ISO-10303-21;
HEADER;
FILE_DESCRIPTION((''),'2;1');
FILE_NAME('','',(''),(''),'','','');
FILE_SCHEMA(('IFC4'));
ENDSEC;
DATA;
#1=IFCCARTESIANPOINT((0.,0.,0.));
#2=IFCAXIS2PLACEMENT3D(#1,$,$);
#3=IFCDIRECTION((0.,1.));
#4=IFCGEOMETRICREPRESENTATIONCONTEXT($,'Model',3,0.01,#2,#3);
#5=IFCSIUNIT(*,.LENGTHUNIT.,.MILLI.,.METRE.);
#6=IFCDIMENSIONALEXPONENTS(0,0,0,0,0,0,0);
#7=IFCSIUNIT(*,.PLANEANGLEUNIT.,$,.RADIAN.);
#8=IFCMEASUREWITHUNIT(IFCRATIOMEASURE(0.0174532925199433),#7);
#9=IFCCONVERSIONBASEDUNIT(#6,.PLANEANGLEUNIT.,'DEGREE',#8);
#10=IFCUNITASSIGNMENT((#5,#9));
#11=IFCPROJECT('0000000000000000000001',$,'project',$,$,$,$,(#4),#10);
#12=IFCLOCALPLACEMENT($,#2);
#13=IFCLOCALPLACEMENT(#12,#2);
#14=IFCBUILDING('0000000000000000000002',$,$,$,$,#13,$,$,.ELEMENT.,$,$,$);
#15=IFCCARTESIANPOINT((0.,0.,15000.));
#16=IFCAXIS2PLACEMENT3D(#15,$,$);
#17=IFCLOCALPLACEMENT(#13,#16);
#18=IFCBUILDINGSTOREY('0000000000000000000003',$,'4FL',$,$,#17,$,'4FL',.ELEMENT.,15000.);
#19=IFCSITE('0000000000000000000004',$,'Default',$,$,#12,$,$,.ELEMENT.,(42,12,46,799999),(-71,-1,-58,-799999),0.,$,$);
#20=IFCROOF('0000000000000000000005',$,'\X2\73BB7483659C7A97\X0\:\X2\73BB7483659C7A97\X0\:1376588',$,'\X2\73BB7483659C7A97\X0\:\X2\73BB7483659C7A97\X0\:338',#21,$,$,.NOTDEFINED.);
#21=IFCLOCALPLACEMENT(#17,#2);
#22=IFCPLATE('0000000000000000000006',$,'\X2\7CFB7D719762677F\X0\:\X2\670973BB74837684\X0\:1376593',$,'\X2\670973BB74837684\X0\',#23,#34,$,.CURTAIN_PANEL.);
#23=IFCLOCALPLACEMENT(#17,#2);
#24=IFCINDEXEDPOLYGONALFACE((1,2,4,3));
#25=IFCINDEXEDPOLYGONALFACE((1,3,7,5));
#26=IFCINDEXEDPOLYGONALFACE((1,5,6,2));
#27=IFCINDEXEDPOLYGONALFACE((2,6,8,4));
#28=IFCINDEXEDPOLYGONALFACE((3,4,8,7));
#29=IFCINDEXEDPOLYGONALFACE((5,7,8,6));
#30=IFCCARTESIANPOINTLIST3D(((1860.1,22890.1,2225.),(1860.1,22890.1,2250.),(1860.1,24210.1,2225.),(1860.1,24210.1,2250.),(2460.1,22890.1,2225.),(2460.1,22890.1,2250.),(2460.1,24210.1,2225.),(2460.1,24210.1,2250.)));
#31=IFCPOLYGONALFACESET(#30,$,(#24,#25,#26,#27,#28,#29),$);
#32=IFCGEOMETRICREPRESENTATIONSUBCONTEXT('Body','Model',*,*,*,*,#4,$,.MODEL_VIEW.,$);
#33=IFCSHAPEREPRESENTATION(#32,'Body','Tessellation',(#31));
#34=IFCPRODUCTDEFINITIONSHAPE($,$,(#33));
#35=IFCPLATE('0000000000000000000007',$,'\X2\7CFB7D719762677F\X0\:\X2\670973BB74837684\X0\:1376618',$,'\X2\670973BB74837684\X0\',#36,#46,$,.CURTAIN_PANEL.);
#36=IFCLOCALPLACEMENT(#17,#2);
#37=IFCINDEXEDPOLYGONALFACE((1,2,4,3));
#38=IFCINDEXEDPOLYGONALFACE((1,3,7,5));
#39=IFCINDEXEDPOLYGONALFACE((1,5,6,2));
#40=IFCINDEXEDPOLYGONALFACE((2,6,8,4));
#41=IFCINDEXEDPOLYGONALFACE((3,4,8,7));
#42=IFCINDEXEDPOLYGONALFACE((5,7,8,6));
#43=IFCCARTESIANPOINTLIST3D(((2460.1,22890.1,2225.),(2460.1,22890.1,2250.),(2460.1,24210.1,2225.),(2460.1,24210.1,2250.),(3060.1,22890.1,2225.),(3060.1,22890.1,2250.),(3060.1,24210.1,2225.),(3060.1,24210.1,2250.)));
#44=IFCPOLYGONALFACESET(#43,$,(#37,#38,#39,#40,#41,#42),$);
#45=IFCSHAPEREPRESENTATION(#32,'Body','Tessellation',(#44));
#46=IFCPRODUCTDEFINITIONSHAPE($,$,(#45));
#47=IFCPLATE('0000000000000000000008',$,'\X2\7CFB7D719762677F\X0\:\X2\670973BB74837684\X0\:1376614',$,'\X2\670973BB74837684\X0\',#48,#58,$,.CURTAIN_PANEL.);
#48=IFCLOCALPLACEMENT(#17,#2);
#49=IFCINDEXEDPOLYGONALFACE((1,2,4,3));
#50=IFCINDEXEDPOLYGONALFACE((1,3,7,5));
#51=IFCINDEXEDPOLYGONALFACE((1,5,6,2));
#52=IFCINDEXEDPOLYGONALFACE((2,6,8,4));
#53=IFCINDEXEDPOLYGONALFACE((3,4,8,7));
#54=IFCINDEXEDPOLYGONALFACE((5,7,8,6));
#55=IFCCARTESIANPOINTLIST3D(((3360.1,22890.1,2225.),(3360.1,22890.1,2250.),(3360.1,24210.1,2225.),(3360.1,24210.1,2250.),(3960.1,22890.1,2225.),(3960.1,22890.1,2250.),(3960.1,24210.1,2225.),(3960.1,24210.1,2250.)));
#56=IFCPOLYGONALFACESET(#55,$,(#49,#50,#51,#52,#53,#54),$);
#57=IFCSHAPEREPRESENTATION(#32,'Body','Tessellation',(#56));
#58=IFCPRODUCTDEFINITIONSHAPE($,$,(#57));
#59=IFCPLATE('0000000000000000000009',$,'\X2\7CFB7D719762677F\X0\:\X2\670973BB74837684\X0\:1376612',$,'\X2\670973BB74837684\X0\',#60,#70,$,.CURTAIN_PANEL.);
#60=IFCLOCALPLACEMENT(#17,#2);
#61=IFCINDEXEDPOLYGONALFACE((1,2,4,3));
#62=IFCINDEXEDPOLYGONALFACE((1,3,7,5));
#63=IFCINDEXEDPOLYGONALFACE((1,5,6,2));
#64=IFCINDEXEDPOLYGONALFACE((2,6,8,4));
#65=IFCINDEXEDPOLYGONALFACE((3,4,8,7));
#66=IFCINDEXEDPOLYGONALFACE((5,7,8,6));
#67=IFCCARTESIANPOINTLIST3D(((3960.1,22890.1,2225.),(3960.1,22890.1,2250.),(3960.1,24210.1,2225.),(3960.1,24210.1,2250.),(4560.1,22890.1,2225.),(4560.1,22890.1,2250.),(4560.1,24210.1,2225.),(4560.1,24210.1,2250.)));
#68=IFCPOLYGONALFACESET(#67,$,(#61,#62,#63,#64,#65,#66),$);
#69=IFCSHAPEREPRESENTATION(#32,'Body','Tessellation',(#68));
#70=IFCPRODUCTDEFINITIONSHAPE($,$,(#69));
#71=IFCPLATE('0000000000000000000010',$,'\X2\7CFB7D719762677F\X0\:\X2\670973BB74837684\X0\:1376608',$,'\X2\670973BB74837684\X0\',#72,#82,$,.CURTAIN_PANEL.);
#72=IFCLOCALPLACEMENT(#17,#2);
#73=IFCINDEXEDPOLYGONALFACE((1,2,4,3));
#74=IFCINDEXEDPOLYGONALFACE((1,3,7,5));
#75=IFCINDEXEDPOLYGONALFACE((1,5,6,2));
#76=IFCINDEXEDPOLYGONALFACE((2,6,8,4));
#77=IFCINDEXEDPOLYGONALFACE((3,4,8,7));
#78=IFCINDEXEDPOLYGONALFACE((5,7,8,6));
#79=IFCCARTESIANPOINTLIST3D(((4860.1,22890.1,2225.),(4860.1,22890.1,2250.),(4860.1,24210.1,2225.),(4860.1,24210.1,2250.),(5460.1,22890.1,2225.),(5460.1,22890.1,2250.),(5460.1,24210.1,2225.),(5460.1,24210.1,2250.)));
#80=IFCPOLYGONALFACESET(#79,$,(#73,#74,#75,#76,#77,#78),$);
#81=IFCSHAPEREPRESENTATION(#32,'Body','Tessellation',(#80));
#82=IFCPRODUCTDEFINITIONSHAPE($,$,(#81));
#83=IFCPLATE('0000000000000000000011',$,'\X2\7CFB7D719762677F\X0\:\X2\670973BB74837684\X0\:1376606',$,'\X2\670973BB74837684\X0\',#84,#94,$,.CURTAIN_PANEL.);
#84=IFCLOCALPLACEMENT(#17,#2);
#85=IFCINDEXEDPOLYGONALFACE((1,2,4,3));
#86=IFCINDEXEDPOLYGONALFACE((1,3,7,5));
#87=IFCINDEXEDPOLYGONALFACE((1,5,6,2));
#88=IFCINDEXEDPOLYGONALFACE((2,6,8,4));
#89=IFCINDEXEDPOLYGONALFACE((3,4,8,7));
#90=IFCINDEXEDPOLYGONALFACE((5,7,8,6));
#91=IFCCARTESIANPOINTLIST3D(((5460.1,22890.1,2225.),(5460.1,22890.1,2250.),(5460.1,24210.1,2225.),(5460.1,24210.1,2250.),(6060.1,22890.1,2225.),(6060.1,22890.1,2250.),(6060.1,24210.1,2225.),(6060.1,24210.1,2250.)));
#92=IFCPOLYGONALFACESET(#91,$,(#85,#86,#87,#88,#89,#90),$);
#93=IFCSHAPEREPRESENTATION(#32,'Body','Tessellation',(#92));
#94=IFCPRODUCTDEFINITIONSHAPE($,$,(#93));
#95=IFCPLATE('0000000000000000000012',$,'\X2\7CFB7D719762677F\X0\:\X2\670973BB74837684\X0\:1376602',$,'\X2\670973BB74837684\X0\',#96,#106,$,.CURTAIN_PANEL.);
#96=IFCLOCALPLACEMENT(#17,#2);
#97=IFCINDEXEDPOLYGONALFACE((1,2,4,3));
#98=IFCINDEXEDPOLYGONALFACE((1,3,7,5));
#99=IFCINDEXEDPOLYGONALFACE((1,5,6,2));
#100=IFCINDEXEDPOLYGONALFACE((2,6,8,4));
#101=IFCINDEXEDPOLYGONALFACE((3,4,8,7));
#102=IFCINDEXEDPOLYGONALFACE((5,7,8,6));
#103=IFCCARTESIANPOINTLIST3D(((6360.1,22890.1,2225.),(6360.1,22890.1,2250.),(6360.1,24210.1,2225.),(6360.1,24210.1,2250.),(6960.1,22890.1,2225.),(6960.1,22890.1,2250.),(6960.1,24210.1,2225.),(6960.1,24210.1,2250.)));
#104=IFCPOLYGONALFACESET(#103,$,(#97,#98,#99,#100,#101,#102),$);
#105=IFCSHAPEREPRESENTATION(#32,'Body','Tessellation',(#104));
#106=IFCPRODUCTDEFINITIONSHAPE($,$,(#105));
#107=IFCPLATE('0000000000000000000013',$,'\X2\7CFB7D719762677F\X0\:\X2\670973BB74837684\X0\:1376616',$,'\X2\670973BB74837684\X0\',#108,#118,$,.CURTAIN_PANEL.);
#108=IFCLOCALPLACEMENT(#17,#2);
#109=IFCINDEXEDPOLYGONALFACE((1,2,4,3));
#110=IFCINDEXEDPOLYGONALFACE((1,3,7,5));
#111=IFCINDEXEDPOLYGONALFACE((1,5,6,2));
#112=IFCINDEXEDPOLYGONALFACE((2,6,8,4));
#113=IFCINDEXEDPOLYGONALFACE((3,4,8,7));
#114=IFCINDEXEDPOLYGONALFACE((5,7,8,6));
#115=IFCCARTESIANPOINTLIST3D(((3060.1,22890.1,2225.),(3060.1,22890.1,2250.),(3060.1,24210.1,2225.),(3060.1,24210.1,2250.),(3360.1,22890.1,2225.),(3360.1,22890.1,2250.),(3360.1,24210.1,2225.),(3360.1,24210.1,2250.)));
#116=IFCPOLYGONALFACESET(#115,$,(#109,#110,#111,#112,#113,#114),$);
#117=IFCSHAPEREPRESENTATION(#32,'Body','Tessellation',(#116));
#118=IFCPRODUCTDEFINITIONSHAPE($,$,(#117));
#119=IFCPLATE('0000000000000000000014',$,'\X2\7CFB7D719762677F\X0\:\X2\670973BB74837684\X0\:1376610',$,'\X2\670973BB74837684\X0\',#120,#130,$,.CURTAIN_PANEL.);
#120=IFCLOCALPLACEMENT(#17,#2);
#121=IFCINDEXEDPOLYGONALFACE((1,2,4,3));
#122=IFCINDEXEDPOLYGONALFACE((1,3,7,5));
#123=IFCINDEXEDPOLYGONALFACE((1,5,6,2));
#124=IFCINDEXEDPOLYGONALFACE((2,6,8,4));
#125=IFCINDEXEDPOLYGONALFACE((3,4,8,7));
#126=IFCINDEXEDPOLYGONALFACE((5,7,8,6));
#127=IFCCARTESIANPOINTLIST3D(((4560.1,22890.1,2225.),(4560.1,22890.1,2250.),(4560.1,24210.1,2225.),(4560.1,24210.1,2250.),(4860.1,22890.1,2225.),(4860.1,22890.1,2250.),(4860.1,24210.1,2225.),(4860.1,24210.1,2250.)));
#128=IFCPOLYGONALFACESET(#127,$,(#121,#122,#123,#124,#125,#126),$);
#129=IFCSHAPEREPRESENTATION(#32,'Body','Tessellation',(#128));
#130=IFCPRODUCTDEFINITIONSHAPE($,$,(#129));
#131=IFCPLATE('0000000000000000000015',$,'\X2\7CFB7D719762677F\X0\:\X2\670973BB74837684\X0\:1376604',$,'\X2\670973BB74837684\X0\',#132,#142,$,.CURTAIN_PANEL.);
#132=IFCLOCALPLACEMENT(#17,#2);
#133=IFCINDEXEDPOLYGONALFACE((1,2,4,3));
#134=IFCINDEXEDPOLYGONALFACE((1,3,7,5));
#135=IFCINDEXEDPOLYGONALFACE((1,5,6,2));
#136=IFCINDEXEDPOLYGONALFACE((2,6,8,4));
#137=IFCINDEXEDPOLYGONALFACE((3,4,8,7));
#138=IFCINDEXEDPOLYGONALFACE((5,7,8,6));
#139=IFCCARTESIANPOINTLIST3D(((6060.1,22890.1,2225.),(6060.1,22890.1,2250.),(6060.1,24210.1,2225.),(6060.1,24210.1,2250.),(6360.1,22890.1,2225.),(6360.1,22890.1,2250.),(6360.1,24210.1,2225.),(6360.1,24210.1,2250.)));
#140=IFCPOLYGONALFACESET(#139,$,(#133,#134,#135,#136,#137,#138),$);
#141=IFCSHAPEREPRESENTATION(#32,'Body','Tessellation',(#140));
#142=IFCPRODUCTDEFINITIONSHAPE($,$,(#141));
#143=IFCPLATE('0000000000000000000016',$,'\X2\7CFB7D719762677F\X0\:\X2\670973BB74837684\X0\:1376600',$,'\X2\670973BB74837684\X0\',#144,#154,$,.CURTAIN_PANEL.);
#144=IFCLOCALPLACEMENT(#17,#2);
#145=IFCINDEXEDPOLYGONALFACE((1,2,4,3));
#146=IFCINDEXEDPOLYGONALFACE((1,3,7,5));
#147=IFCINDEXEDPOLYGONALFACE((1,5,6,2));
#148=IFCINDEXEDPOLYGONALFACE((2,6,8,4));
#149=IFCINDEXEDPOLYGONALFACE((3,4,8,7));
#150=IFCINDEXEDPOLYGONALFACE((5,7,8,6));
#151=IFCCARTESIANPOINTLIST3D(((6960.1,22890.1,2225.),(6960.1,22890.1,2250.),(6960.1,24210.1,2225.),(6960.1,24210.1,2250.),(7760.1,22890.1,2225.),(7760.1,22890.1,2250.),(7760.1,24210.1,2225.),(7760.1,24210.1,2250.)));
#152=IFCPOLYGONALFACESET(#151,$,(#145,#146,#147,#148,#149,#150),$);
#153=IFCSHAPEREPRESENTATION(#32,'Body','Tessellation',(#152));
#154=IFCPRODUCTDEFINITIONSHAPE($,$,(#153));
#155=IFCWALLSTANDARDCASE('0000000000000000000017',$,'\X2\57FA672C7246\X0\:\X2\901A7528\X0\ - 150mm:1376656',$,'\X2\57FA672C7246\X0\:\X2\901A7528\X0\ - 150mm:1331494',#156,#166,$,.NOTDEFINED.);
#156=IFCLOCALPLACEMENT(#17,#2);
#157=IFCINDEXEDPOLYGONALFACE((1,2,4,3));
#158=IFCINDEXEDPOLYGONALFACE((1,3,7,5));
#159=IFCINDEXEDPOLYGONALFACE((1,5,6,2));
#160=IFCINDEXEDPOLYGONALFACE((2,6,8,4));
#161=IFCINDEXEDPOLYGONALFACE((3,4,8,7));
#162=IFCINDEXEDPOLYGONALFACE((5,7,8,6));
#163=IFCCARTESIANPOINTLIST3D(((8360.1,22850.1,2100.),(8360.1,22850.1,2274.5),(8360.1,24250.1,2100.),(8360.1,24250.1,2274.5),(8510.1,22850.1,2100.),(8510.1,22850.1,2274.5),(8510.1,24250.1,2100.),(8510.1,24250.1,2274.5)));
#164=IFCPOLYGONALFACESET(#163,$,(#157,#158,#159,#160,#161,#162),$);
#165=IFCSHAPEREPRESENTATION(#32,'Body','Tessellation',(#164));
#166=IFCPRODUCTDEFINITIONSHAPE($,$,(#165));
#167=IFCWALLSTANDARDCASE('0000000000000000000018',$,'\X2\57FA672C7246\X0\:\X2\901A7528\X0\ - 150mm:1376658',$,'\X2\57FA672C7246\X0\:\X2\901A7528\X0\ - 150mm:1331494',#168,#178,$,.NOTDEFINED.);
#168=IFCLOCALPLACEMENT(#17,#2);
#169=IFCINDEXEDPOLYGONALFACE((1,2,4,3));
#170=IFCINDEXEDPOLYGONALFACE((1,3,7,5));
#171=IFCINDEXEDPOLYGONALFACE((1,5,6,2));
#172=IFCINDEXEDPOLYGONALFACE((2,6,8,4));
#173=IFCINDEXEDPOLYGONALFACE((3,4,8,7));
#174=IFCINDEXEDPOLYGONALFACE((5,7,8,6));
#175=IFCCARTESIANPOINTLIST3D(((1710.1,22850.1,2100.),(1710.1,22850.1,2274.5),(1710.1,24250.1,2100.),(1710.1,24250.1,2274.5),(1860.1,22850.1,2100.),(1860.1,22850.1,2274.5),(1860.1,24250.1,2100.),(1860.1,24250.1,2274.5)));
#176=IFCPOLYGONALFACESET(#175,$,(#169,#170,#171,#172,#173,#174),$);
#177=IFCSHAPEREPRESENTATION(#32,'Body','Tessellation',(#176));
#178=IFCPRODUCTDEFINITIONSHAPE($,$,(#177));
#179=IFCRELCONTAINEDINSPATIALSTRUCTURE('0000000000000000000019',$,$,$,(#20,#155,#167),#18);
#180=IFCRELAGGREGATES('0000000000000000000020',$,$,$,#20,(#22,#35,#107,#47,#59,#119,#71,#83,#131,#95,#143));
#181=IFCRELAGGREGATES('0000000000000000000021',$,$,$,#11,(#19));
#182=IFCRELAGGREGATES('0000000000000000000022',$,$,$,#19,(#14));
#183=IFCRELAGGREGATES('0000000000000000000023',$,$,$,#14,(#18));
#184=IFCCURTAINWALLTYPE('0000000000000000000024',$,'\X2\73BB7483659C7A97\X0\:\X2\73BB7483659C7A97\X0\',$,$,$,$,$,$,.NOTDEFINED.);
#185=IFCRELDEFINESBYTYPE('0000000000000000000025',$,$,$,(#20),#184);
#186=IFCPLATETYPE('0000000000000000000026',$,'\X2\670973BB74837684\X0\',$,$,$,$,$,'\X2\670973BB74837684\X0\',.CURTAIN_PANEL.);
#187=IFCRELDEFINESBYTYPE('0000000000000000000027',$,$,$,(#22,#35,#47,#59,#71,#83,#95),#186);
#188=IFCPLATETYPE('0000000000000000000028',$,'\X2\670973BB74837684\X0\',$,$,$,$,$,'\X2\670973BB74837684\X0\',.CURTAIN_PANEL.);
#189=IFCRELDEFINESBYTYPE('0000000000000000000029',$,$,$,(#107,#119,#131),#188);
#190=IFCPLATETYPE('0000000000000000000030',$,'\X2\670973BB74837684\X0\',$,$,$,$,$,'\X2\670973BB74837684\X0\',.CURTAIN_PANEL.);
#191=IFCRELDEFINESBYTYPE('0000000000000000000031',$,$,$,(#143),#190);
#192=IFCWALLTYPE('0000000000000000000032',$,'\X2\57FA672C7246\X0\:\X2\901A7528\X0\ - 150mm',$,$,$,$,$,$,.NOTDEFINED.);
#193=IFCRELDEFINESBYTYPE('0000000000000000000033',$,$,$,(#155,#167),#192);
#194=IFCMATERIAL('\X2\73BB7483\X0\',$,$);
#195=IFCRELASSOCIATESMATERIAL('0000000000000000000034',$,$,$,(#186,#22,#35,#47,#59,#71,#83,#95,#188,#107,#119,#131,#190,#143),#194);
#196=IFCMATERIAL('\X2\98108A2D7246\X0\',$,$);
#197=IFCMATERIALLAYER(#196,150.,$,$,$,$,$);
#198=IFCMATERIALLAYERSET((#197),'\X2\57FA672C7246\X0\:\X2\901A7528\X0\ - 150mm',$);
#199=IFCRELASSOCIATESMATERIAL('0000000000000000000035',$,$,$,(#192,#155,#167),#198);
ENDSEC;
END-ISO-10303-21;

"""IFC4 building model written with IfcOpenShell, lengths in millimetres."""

from ifc_helpers import new_model, entity, si_unit, converted_unit, direction, frame, frame_2d, origin, origin_2d_with_axis, place, context, subcontext, project, spatial, rectangle, extrude, source, transform, mapped, material, layer, layer_set, layer_usage, type_object, type_shapes, element, aggregate, save


model = new_model("IFC4")

# Units and contexts
model_context = context("Model", 3, precision=0.01, world=origin(), true_north=direction((0.0, 1.0)))
body_context = subcontext(model_context, "Body", "Model", "MODEL_VIEW")
ifc_project = project(units=[si_unit("LENGTHUNIT", "METRE", prefix="MILLI"), converted_unit("PLANEANGLEUNIT", "DEGREE", entity("IfcRatioMeasure", 0.0174532925199433), si_unit("PLANEANGLEUNIT", "RADIAN"), dimensions=[0, 0, 0, 0, 0, 0, 0])], contexts=[model_context])

# Site, building, storey
site_placement = place(None, origin())
site = spatial("IfcSite", under=ifc_project, at=site_placement, Name="Default", CompositionType="ELEMENT", RefLatitude=(42, 12, 46, 799999), RefLongitude=(-71, -1, -58, -799999), RefElevation=0.0)
building_placement = place(site_placement, origin())
building = spatial("IfcBuilding", under=site, at=building_placement, CompositionType="ELEMENT")
storey_placement = place(building_placement, frame((0.0, 0.0, 15000.0)))
storey = spatial("IfcBuildingStorey", under=building, at=storey_placement, Name="4FL", LongName="4FL", CompositionType="ELEMENT", Elevation=15000.0)

# Roof, plates
curtain_wall_type = type_object("IfcCurtainWallType", Name="玻璃斜窗:玻璃斜窗", PredefinedType="NOTDEFINED")
roof_placement = place(storey_placement, frame((0.0, 0.0, -15000.0)))
roof = element("IfcRoof", 1, at=roof_placement, inside=storey, type_object=curtain_wall_type, Name="玻璃斜窗:玻璃斜窗:1376588", ObjectType="玻璃斜窗:玻璃斜窗:338", PredefinedType="NOTDEFINED")
ifc_material_1 = material(Name="玻璃")
plate_type_1 = type_object("IfcPlateType", Name="有玻璃的", ElementType="有玻璃的", PredefinedType="CURTAIN_PANEL", material=ifc_material_1)
shared_shape_1 = source(origin(), body_context, "Body", "SweptSolid", [
    extrude(rectangle(XDim=25.0, YDim=600.0, at=origin_2d_with_axis()), frame((300.0, 12.5, 0.0), z_axis=(0.0, 0.0, 1.0), x_axis=(0.0, 1.0, 0.0)), (0.0, 0.0, 1.0), 1320.0),
])
type_shapes(plate_type_1, [shared_shape_1])
plate_1_placement = place(roof_placement, frame((1860.1, 22890.1, 17250.0), z_axis=(0.0, 1.0, 0.0), x_axis=(1.0, 0.0, 0.0)))
plate_1 = element("IfcPlate", 2, at=plate_1_placement, type_object=plate_type_1, material=ifc_material_1, Name="系統面板:有玻璃的:1376593", ObjectType="有玻璃的", PredefinedType="CURTAIN_PANEL", context=body_context, shape_type="MappedRepresentation", body=[
    mapped(shared_shape_1, transform((0.0, 0.0, 0.0), scale=1.0)),
])
plate_2_placement = place(roof_placement, frame((2460.1, 22890.1, 17250.0), z_axis=(0.0, 1.0, 0.0), x_axis=(1.0, 0.0, 0.0)))
plate_2 = element("IfcPlate", 3, at=plate_2_placement, type_object=plate_type_1, material=ifc_material_1, Name="系統面板:有玻璃的:1376618", ObjectType="有玻璃的", PredefinedType="CURTAIN_PANEL", context=body_context, shape_type="MappedRepresentation", body=[
    mapped(shared_shape_1, transform((0.0, 0.0, 0.0), scale=1.0)),
])
plate_3_placement = place(roof_placement, frame((3360.1, 22890.1, 17250.0), z_axis=(0.0, 1.0, 0.0), x_axis=(1.0, 0.0, 0.0)))
plate_3 = element("IfcPlate", 4, at=plate_3_placement, type_object=plate_type_1, material=ifc_material_1, Name="系統面板:有玻璃的:1376614", ObjectType="有玻璃的", PredefinedType="CURTAIN_PANEL", context=body_context, shape_type="MappedRepresentation", body=[
    mapped(shared_shape_1, transform((0.0, 0.0, 0.0), scale=1.0)),
])
plate_4_placement = place(roof_placement, frame((3960.1, 22890.1, 17250.0), z_axis=(0.0, 1.0, 0.0), x_axis=(1.0, 0.0, 0.0)))
plate_4 = element("IfcPlate", 5, at=plate_4_placement, type_object=plate_type_1, material=ifc_material_1, Name="系統面板:有玻璃的:1376612", ObjectType="有玻璃的", PredefinedType="CURTAIN_PANEL", context=body_context, shape_type="MappedRepresentation", body=[
    mapped(shared_shape_1, transform((0.0, 0.0, 0.0), scale=1.0)),
])
plate_5_placement = place(roof_placement, frame((4860.1, 22890.1, 17250.0), z_axis=(0.0, 1.0, 0.0), x_axis=(1.0, 0.0, 0.0)))
plate_5 = element("IfcPlate", 6, at=plate_5_placement, type_object=plate_type_1, material=ifc_material_1, Name="系統面板:有玻璃的:1376608", ObjectType="有玻璃的", PredefinedType="CURTAIN_PANEL", context=body_context, shape_type="MappedRepresentation", body=[
    mapped(shared_shape_1, transform((0.0, 0.0, 0.0), scale=1.0)),
])
plate_6_placement = place(roof_placement, frame((5460.1, 22890.1, 17250.0), z_axis=(0.0, 1.0, 0.0), x_axis=(1.0, 0.0, 0.0)))
plate_6 = element("IfcPlate", 7, at=plate_6_placement, type_object=plate_type_1, material=ifc_material_1, Name="系統面板:有玻璃的:1376606", ObjectType="有玻璃的", PredefinedType="CURTAIN_PANEL", context=body_context, shape_type="MappedRepresentation", body=[
    mapped(shared_shape_1, transform((0.0, 0.0, 0.0), scale=1.0)),
])
plate_7_placement = place(roof_placement, frame((6360.1, 22890.1, 17250.0), z_axis=(0.0, 1.0, 0.0), x_axis=(1.0, 0.0, 0.0)))
plate_7 = element("IfcPlate", 8, at=plate_7_placement, type_object=plate_type_1, material=ifc_material_1, Name="系統面板:有玻璃的:1376602", ObjectType="有玻璃的", PredefinedType="CURTAIN_PANEL", context=body_context, shape_type="MappedRepresentation", body=[
    mapped(shared_shape_1, transform((0.0, 0.0, 0.0), scale=1.0)),
])
plate_type_2 = type_object("IfcPlateType", Name="有玻璃的", ElementType="有玻璃的", PredefinedType="CURTAIN_PANEL", material=ifc_material_1)
shared_shape_2 = source(origin(), body_context, "Body", "SweptSolid", [
    extrude(rectangle(XDim=25.0, YDim=300.0, at=origin_2d_with_axis()), frame((150.0, 12.5, 0.0), z_axis=(0.0, 0.0, 1.0), x_axis=(0.0, 1.0, 0.0)), (0.0, 0.0, 1.0), 1320.0),
])
type_shapes(plate_type_2, [shared_shape_2])
plate_8_placement = place(roof_placement, frame((3060.1, 22890.1, 17250.0), z_axis=(0.0, 1.0, 0.0), x_axis=(1.0, 0.0, 0.0)))
plate_8 = element("IfcPlate", 9, at=plate_8_placement, type_object=plate_type_2, material=ifc_material_1, Name="系統面板:有玻璃的:1376616", ObjectType="有玻璃的", PredefinedType="CURTAIN_PANEL", context=body_context, shape_type="MappedRepresentation", body=[
    mapped(shared_shape_2, transform((0.0, 0.0, 0.0), scale=1.0)),
])
plate_9_placement = place(roof_placement, frame((4560.1, 22890.1, 17250.0), z_axis=(0.0, 1.0, 0.0), x_axis=(1.0, 0.0, 0.0)))
plate_9 = element("IfcPlate", 10, at=plate_9_placement, type_object=plate_type_2, material=ifc_material_1, Name="系統面板:有玻璃的:1376610", ObjectType="有玻璃的", PredefinedType="CURTAIN_PANEL", context=body_context, shape_type="MappedRepresentation", body=[
    mapped(shared_shape_2, transform((0.0, 0.0, 0.0), scale=1.0)),
])
plate_10_placement = place(roof_placement, frame((6060.1, 22890.1, 17250.0), z_axis=(0.0, 1.0, 0.0), x_axis=(1.0, 0.0, 0.0)))
plate_10 = element("IfcPlate", 11, at=plate_10_placement, type_object=plate_type_2, material=ifc_material_1, Name="系統面板:有玻璃的:1376604", ObjectType="有玻璃的", PredefinedType="CURTAIN_PANEL", context=body_context, shape_type="MappedRepresentation", body=[
    mapped(shared_shape_2, transform((0.0, 0.0, 0.0), scale=1.0)),
])
plate_type_3 = type_object("IfcPlateType", Name="有玻璃的", ElementType="有玻璃的", PredefinedType="CURTAIN_PANEL", material=ifc_material_1)
shared_shape_3 = source(origin(), body_context, "Body", "SweptSolid", [
    extrude(rectangle(XDim=25.0, YDim=800.0, at=origin_2d_with_axis()), frame((400.0, 12.5, 0.0), z_axis=(0.0, 0.0, 1.0), x_axis=(0.0, 1.0, 0.0)), (0.0, 0.0, 1.0), 1320.0),
])
type_shapes(plate_type_3, [shared_shape_3])
plate_11_placement = place(roof_placement, frame((6960.1, 22890.1, 17250.0), z_axis=(0.0, 1.0, 0.0), x_axis=(1.0, 0.0, 0.0)))
plate_11 = element("IfcPlate", 12, at=plate_11_placement, type_object=plate_type_3, material=ifc_material_1, Name="系統面板:有玻璃的:1376600", ObjectType="有玻璃的", PredefinedType="CURTAIN_PANEL", context=body_context, shape_type="MappedRepresentation", body=[
    mapped(shared_shape_3, transform((0.0, 0.0, 0.0), scale=1.0)),
])
aggregate(roof, [plate_1, plate_2, plate_8, plate_3, plate_4, plate_9, plate_5, plate_6, plate_10, plate_7, plate_11])

# Walls, openings
ifc_material_2 = material(Name="預設牆")
ifc_layer_1 = layer(ifc_material_2, 150.0)
ifc_layer_set_1 = layer_set([ifc_layer_1], Name="基本牆:通用 - 150mm")
ifc_layer_usage_1 = layer_usage(ifc_layer_set_1, "AXIS2", "NEGATIVE", 75.0)
wall_type_1 = type_object("IfcWallType", Name="基本牆:通用 - 150mm", PredefinedType="NOTDEFINED", material=ifc_layer_set_1)
wall_1_placement = place(storey_placement, frame((8435.1, 22850.1, 2100.0), z_axis=(0.0, 0.0, 1.0), x_axis=(0.0, 1.0, 0.0)))
wall_1 = element("IfcWallStandardCase", 13, at=wall_1_placement, inside=storey, type_object=wall_type_1, material=ifc_layer_usage_1, Name="基本牆:通用 - 150mm:1376656", ObjectType="基本牆:通用 - 150mm:1331494", PredefinedType="NOTDEFINED", context=body_context, shape_type="SweptSolid", body=[
    extrude(rectangle(XDim=1400.0, YDim=150.0, at=frame_2d((700.0, 0.0), x_axis=(-1.0, 0.0))), origin(), (0.0, 0.0, 1.0), 174.4),
])
opening_1_placement = place(wall_1_placement, frame((1400.0, 75.0, -2100.0)))
element("IfcOpeningElement", 14, at=opening_1_placement, cuts=wall_1, ObjectType="Opening", PredefinedType="OPENING", context=body_context, shape_type="SweptSolid", body=[
    extrude(rectangle(XDim=2100.0, YDim=1400.0, at=frame_2d((1050.0, 700.0), x_axis=(1.0, 0.0))), frame((0.0, 0.0, 0.0), z_axis=(0.0, -1.0, 0.0), x_axis=(0.0, 0.0, 1.0)), (0.0, 0.0, 1.0), 150.0),
])
ifc_layer_usage_2 = layer_usage(ifc_layer_set_1, "AXIS2", "POSITIVE", -75.0)
wall_2_placement = place(storey_placement, frame((1785.1, 22850.1, 2100.0), z_axis=(0.0, 0.0, 1.0), x_axis=(0.0, 1.0, 0.0)))
wall_2 = element("IfcWallStandardCase", 15, at=wall_2_placement, inside=storey, type_object=wall_type_1, material=ifc_layer_usage_2, Name="基本牆:通用 - 150mm:1376658", ObjectType="基本牆:通用 - 150mm:1331494", PredefinedType="NOTDEFINED", context=body_context, shape_type="SweptSolid", body=[
    extrude(rectangle(XDim=1400.0, YDim=150.0, at=frame_2d((700.0, 0.0), x_axis=(-1.0, 0.0))), origin(), (0.0, 0.0, 1.0), 174.4),
])
opening_2_placement = place(wall_2_placement, frame((0.0, -75.0, -2100.0)))
element("IfcOpeningElement", 16, at=opening_2_placement, cuts=wall_2, ObjectType="Opening", PredefinedType="OPENING", context=body_context, shape_type="SweptSolid", body=[
    extrude(rectangle(XDim=2100.0, YDim=1400.0, at=frame_2d((1050.0, 700.0), x_axis=(1.0, 0.0))), frame((0.0, 0.0, 0.0), z_axis=(0.0, 1.0, 0.0), x_axis=(0.0, 0.0, 1.0)), (0.0, 0.0, 1.0), 150.0),
])

save(model, "model.ifc")
